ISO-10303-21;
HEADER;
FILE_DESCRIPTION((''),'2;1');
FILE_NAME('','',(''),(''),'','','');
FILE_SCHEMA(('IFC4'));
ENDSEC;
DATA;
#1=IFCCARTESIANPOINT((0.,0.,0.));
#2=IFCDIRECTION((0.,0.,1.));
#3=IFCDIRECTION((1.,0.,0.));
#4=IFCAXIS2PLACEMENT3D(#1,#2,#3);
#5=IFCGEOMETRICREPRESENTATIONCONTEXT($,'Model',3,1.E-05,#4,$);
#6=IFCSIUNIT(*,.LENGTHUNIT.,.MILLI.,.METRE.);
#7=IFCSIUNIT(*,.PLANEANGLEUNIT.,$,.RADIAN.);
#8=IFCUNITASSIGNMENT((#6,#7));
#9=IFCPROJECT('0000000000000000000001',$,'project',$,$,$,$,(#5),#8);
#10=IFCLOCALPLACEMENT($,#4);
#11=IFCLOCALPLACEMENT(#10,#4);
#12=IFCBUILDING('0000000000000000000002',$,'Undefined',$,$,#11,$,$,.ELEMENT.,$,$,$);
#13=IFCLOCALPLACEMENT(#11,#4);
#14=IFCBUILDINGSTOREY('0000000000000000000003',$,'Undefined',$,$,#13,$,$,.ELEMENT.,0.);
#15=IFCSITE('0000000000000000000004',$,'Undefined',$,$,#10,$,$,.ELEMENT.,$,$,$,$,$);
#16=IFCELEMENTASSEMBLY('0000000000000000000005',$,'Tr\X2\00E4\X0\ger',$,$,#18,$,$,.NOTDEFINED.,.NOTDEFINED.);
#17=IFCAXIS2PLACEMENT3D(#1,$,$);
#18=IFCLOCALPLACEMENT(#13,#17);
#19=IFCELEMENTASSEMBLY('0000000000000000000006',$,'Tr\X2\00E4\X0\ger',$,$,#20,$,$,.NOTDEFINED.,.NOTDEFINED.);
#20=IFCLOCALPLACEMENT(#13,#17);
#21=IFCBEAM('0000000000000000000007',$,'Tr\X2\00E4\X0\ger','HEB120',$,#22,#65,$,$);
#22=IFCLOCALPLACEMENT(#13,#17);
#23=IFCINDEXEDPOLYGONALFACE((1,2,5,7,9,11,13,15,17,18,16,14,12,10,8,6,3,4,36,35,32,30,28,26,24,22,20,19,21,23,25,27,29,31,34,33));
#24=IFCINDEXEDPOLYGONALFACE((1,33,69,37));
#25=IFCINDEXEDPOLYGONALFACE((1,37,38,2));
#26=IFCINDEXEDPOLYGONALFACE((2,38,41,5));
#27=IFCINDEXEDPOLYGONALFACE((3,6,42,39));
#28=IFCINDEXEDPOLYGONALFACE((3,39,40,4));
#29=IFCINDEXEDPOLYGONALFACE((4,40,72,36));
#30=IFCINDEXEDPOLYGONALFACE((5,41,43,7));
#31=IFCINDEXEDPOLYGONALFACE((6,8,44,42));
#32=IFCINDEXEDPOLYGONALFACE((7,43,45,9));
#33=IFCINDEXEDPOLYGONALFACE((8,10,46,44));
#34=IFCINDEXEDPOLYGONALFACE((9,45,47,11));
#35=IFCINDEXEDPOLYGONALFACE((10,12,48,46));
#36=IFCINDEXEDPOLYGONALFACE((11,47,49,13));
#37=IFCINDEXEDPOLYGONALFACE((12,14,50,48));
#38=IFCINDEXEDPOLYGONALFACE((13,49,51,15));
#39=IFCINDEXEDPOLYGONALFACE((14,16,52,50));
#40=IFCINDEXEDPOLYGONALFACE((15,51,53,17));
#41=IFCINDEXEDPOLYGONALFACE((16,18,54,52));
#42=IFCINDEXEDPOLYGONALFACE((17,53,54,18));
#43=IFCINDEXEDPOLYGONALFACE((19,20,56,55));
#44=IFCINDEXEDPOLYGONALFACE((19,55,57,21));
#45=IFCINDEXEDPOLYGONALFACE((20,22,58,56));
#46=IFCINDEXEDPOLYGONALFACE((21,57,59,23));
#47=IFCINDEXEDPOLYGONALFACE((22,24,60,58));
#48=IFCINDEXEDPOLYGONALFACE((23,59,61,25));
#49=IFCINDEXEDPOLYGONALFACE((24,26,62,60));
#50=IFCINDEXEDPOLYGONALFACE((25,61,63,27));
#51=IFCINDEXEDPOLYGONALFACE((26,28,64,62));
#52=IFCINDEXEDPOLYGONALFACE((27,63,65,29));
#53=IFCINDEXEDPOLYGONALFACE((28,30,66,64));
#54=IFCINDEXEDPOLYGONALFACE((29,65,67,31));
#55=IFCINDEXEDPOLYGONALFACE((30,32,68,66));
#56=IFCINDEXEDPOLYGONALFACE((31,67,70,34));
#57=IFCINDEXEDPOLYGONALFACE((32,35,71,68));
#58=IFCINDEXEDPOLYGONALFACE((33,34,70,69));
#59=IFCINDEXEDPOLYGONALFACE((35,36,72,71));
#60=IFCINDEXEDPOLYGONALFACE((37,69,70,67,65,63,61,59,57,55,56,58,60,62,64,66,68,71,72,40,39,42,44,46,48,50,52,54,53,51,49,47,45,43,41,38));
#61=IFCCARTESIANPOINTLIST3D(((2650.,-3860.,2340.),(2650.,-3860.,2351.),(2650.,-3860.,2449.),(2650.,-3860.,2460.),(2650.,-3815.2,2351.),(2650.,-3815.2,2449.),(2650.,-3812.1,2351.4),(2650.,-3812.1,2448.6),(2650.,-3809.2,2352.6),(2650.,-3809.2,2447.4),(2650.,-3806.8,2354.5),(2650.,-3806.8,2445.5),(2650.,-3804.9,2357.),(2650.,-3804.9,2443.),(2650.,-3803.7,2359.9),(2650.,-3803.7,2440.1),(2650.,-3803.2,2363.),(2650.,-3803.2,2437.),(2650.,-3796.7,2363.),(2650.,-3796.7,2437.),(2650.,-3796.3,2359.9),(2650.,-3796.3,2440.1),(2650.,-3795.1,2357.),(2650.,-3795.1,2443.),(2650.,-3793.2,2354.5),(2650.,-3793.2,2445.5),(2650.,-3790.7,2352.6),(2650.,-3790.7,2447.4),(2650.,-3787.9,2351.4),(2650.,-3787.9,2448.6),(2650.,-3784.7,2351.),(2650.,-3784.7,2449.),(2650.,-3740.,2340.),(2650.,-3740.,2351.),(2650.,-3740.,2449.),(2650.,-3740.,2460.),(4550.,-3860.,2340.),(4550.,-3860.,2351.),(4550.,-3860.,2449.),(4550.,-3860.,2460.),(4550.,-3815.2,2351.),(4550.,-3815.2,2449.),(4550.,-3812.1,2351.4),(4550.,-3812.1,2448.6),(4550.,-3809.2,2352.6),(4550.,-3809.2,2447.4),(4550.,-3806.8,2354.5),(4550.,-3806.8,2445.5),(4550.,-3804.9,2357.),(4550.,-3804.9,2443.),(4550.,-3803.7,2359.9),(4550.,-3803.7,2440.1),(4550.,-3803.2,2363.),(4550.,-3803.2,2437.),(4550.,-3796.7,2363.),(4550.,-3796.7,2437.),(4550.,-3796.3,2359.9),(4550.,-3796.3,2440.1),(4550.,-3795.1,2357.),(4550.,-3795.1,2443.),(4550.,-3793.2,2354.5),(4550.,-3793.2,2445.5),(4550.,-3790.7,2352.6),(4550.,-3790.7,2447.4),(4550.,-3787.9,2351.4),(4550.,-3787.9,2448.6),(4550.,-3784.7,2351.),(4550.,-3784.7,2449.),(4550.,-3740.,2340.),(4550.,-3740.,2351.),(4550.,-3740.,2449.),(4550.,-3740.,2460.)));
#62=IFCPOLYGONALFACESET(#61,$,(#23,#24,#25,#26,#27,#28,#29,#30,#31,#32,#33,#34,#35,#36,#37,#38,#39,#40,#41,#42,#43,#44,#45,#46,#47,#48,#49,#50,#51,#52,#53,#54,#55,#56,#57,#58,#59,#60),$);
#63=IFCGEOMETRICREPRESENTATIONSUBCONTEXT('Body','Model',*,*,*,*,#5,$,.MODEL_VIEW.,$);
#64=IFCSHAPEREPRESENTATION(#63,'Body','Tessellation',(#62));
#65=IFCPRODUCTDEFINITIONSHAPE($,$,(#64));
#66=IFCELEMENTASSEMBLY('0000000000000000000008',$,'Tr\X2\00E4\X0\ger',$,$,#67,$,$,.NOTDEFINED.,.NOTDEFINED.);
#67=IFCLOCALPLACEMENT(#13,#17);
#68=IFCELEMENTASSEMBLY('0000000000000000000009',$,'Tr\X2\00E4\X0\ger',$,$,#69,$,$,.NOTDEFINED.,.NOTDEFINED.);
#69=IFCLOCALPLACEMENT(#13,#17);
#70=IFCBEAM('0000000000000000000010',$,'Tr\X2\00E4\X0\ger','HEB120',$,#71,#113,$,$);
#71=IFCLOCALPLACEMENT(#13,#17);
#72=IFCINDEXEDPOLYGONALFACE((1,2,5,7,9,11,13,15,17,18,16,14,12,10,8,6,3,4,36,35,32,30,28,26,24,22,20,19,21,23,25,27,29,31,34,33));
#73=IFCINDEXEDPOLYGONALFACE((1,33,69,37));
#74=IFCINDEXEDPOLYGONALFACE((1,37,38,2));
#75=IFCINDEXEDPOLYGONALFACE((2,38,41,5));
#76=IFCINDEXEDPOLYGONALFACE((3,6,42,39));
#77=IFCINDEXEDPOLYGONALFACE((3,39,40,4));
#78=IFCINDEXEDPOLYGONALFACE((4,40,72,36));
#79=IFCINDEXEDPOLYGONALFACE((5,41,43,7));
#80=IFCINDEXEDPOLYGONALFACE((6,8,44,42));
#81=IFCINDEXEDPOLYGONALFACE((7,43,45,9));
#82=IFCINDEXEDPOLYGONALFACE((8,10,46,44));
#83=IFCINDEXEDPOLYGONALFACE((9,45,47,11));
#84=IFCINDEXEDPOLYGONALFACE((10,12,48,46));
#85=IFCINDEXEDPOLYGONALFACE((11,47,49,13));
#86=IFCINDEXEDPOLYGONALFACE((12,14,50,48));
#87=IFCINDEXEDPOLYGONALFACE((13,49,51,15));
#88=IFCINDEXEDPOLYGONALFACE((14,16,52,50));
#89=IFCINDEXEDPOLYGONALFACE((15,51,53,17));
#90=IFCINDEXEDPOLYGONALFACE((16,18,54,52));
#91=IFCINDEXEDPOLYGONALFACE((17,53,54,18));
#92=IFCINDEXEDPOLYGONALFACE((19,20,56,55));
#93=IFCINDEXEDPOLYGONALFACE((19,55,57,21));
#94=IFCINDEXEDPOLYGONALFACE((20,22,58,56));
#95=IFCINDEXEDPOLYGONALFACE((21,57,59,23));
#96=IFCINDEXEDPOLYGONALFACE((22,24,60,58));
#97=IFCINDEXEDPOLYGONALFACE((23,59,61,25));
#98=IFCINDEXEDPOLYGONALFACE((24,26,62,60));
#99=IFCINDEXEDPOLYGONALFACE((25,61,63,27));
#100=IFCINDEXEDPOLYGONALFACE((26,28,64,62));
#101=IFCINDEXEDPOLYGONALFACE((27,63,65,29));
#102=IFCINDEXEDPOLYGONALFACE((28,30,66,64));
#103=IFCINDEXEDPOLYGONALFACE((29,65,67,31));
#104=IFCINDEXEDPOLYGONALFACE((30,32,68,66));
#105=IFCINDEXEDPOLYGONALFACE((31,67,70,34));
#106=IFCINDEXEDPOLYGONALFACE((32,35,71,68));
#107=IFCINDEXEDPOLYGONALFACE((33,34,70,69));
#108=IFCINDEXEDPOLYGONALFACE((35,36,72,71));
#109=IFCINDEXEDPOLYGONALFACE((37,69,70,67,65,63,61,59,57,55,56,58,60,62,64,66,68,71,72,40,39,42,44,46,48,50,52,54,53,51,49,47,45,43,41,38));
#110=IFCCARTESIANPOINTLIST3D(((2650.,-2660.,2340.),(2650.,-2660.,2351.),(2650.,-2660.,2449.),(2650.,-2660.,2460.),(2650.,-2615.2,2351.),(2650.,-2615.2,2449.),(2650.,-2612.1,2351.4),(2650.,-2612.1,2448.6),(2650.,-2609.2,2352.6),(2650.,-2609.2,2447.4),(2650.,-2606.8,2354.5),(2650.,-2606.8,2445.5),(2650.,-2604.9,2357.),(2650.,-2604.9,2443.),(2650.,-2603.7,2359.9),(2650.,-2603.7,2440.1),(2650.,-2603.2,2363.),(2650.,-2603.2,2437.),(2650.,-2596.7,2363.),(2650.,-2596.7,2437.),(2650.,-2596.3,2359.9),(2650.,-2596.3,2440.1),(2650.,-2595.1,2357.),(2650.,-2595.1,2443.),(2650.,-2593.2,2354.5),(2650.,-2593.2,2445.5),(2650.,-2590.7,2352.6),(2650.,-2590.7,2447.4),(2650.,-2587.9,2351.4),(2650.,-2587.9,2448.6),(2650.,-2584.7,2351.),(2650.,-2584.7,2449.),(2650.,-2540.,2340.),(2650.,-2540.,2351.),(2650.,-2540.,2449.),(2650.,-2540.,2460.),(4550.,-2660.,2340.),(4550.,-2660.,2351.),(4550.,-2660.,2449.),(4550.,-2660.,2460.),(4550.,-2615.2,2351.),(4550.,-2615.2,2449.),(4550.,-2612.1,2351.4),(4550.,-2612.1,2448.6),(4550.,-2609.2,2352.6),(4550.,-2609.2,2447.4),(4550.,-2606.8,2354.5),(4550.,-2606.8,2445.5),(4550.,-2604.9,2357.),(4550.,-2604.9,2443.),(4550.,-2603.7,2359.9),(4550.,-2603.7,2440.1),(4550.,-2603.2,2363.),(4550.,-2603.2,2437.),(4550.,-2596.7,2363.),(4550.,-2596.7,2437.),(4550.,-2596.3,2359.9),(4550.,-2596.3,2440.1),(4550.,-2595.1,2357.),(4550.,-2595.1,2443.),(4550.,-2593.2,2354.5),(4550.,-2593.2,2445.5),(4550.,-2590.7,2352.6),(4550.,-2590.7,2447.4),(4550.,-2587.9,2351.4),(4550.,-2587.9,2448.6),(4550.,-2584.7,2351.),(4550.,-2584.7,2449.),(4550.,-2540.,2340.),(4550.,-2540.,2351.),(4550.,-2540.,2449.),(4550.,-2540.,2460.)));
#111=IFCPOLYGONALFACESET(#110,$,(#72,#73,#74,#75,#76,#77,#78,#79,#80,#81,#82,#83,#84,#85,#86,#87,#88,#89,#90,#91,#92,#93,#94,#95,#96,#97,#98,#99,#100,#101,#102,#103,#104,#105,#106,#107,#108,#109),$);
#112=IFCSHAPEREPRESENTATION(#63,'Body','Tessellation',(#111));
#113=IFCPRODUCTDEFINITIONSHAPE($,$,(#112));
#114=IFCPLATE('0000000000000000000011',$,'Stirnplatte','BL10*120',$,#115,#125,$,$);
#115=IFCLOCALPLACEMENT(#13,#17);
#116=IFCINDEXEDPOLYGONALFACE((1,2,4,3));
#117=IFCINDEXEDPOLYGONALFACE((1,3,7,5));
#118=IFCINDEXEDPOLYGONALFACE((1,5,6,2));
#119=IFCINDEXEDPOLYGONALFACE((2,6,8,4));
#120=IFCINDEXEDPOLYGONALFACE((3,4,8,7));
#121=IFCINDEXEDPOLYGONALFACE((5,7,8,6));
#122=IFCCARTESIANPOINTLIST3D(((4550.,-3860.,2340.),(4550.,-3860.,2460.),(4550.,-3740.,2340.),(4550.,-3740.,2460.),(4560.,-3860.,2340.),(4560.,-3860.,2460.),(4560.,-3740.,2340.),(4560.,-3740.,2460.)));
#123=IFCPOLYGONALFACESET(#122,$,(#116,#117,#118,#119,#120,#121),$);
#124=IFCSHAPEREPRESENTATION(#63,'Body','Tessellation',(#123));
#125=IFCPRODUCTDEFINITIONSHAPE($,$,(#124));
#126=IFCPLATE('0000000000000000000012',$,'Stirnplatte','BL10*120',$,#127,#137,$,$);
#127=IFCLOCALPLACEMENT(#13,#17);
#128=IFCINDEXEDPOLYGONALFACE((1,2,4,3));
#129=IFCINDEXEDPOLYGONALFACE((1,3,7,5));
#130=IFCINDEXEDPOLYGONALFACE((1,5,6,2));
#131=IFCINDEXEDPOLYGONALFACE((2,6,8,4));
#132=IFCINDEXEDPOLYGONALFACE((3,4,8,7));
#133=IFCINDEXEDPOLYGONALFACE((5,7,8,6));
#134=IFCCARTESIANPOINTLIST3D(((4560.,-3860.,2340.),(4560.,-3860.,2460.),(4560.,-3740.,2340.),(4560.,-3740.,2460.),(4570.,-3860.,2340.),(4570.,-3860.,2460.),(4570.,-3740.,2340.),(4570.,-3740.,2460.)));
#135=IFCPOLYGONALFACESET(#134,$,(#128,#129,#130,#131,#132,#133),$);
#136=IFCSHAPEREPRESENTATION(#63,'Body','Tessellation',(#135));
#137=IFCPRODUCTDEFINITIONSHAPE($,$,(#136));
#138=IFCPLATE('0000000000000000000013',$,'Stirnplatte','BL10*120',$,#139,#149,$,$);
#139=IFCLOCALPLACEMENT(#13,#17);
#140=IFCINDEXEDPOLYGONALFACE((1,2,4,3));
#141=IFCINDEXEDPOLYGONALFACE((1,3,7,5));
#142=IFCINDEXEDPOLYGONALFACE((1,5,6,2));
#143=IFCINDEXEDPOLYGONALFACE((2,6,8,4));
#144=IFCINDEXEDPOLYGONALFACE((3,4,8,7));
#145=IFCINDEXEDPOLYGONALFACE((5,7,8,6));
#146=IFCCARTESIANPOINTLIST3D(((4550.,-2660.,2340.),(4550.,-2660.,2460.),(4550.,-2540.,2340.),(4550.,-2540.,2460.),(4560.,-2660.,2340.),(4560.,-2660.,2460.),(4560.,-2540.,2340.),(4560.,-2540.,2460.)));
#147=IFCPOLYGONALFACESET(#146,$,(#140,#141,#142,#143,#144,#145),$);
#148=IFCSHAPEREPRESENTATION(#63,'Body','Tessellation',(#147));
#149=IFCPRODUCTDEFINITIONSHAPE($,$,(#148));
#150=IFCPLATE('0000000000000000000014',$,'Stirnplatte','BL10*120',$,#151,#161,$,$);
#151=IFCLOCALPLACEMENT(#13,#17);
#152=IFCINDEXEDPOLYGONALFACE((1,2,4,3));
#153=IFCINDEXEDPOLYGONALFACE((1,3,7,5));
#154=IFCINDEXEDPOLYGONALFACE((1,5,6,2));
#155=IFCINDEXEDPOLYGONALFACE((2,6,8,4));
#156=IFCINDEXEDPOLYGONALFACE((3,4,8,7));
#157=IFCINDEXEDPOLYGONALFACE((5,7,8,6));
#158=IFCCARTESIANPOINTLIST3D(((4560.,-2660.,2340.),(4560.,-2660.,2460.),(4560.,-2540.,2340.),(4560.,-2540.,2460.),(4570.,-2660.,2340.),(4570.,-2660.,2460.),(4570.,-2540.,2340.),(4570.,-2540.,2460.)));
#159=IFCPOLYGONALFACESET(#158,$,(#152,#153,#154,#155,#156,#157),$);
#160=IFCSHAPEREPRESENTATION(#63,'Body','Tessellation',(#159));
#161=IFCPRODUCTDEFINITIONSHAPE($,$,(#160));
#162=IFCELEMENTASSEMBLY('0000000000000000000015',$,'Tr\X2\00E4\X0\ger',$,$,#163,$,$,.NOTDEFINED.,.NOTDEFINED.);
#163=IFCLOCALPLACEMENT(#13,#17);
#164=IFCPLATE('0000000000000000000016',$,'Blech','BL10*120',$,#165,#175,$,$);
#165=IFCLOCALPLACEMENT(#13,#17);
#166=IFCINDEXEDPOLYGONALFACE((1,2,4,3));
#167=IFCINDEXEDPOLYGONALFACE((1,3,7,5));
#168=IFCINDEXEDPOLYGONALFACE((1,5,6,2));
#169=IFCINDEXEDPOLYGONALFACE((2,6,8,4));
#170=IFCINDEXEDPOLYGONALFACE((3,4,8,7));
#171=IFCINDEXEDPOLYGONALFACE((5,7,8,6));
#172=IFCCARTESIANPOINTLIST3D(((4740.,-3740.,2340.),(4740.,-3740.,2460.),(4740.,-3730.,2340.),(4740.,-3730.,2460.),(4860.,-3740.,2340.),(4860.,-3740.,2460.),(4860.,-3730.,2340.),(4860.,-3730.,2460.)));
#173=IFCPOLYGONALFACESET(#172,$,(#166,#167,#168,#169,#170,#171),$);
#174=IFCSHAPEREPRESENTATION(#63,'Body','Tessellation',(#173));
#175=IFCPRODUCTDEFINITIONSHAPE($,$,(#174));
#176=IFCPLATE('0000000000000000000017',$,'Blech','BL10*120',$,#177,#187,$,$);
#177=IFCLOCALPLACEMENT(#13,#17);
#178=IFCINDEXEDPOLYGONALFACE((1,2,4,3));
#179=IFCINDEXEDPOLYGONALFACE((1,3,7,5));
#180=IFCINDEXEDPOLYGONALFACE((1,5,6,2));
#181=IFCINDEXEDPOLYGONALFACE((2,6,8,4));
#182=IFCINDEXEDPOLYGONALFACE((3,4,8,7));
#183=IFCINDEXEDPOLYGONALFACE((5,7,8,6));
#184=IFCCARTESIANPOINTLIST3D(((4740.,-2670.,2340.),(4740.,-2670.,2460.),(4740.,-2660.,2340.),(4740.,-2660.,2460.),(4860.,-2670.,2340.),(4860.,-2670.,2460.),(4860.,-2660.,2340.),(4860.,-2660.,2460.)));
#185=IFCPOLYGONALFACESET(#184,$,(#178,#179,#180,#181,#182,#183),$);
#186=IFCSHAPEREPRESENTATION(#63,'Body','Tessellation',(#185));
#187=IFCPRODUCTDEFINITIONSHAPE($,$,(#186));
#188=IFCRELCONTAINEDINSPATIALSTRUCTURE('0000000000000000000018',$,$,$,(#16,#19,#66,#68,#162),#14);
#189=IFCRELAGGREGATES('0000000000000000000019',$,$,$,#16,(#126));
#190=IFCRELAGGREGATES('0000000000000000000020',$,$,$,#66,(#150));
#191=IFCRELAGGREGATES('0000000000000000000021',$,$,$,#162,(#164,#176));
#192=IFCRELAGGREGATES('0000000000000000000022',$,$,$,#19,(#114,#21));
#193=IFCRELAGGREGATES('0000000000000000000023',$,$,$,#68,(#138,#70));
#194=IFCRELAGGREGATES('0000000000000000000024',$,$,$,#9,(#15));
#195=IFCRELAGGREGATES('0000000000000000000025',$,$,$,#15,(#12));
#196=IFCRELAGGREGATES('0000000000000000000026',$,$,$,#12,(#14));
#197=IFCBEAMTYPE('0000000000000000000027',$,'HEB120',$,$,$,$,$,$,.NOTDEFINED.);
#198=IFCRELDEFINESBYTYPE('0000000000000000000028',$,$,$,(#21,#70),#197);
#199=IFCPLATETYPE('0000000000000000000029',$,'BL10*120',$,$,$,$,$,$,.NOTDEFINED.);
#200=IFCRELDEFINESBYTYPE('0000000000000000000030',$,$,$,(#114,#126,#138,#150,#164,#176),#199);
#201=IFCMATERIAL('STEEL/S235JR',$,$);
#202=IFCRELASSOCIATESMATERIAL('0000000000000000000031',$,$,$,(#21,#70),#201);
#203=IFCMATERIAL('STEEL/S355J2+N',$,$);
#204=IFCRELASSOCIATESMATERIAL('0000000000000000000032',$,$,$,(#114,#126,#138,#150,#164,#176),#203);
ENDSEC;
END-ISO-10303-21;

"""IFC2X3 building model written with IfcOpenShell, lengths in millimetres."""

from ifc_helpers import new_model, si_unit, frame, origin_with_axes, origin_2d_with_axis, place, context, subcontext, project, spatial, polyline, i_section, outline, extrude, clip, halfspace, material, type_object, element, aggregate, save


model = new_model("IFC2X3")

# Units and contexts
model_context = context("Model", 3, precision=1e-05, world=origin_with_axes())
body_context = subcontext(model_context, "Body", "Model", "MODEL_VIEW")
ifc_project = project(units=[si_unit("LENGTHUNIT", "METRE", prefix="MILLI"), si_unit("PLANEANGLEUNIT", "RADIAN")], contexts=[model_context])

# Site, building, storey
site_placement = place(None, origin_with_axes())
site = spatial("IfcSite", under=ifc_project, at=site_placement, Name="Undefined", CompositionType="ELEMENT")
building_placement = place(site_placement, origin_with_axes())
building = spatial("IfcBuilding", under=site, at=building_placement, Name="Undefined", CompositionType="ELEMENT")
storey_placement = place(building_placement, origin_with_axes())
storey = spatial("IfcBuildingStorey", under=building, at=storey_placement, Name="Undefined", CompositionType="ELEMENT", Elevation=0.0)

# Element assemblies, beams
assembly_1_placement = place(storey_placement, origin_with_axes())
assembly_1 = element("IfcElementAssembly", 1, at=assembly_1_placement, inside=storey, Name="Träger", AssemblyPlace="NOTDEFINED", PredefinedType="NOTDEFINED")
ifc_material_1 = material(Name="STEEL/S235JR")
beam_type = type_object("IfcBeamType", Name="HEB120", PredefinedType="NOTDEFINED")
assembly_2_placement = place(storey_placement, origin_with_axes())
assembly_2 = element("IfcElementAssembly", 2, at=assembly_2_placement, inside=storey, Name="Träger", AssemblyPlace="NOTDEFINED", PredefinedType="NOTDEFINED")
beam_1_placement = place(assembly_2_placement, frame((4550.0, -3800.0, 2400.0), z_axis=(0.0, 0.0, 1.0), x_axis=(-1.0, 0.0, 0.0)))
beam_1 = element("IfcBeam", 3, at=beam_1_placement, type_object=beam_type, material=ifc_material_1, Name="Träger", Description="HEB120", context=body_context, shape_type="Clipping", body=[
    clip(clip(extrude(i_section(OverallWidth=120.0, OverallDepth=120.0, WebThickness=6.5, FlangeThickness=11.0, FilletRadius=12.0, at=origin_2d_with_axis()), frame((1910.0, 0.0, 0.0), z_axis=(-1.0, 0.0, 0.0), x_axis=(0.0, -1.0, 0.0)), (0.0, 0.0, 1.0), 1910.0), halfspace(frame((1900.0, 0.0, -60.0), z_axis=(-1.0, 0.0, 0.0), x_axis=(0.0, 1.0, 0.0)), True)), halfspace(frame((0.0, 0.0, -60.0), z_axis=(1.0, 0.0, 0.0), x_axis=(0.0, -1.0, 0.0)), True)),
])
assembly_3_placement = place(storey_placement, origin_with_axes())
assembly_3 = element("IfcElementAssembly", 4, at=assembly_3_placement, inside=storey, Name="Träger", AssemblyPlace="NOTDEFINED", PredefinedType="NOTDEFINED")
assembly_4_placement = place(storey_placement, origin_with_axes())
assembly_4 = element("IfcElementAssembly", 5, at=assembly_4_placement, inside=storey, Name="Träger", AssemblyPlace="NOTDEFINED", PredefinedType="NOTDEFINED")
beam_2_placement = place(assembly_4_placement, frame((4550.0, -2600.0, 2400.0), z_axis=(0.0, 0.0, 1.0), x_axis=(-1.0, 0.0, 0.0)))
beam_2 = element("IfcBeam", 6, at=beam_2_placement, type_object=beam_type, material=ifc_material_1, Name="Träger", Description="HEB120", context=body_context, shape_type="Clipping", body=[
    clip(clip(extrude(i_section(OverallWidth=120.0, OverallDepth=120.0, WebThickness=6.5, FlangeThickness=11.0, FilletRadius=12.0, at=origin_2d_with_axis()), frame((1910.0, 0.0, 0.0), z_axis=(-1.0, 0.0, 0.0), x_axis=(0.0, -1.0, 0.0)), (0.0, 0.0, 1.0), 1910.0), halfspace(frame((1900.0, 0.0, -60.0), z_axis=(-1.0, 0.0, 0.0), x_axis=(0.0, 1.0, 0.0)), True)), halfspace(frame((0.0, 0.0, -60.0), z_axis=(1.0, 0.0, 0.0), x_axis=(0.0, -1.0, 0.0)), True)),
])

# Plates
ifc_material_2 = material(Name="STEEL/S355J2+N")
plate_type = type_object("IfcPlateType", Name="BL10*120", PredefinedType="NOTDEFINED")
plate_1_placement = place(assembly_2_placement, frame((4555.0, -3800.0, 2340.0), z_axis=(-1.0, 0.0, 0.0), x_axis=(0.0, 0.0, 1.0)))
plate_1 = element("IfcPlate", 7, at=plate_1_placement, type_object=plate_type, material=ifc_material_2, Name="Stirnplatte", Description="BL10*120", context=body_context, shape_type="SweptSolid", body=[
    extrude(outline(polyline([(0.0, -60.0), (0.0, 60.0), (120.0, 60.0), (120.0, -60.0), (0.0, -60.0)])), frame((0.0, 0.0, -5.0), z_axis=(0.0, 0.0, 1.0), x_axis=(1.0, 0.0, 0.0)), (0.0, 0.0, 1.0), 10.0),
])
plate_2_placement = place(assembly_1_placement, frame((4565.0, -3800.0, 2340.0), z_axis=(-1.0, 0.0, 0.0), x_axis=(0.0, 0.0, 1.0)))
plate_2 = element("IfcPlate", 8, at=plate_2_placement, type_object=plate_type, material=ifc_material_2, Name="Stirnplatte", Description="BL10*120", context=body_context, shape_type="SweptSolid", body=[
    extrude(outline(polyline([(0.0, -60.0), (0.0, 60.0), (120.0, 60.0), (120.0, -60.0), (0.0, -60.0)])), frame((0.0, 0.0, -5.0), z_axis=(0.0, 0.0, 1.0), x_axis=(1.0, 0.0, 0.0)), (0.0, 0.0, 1.0), 10.0),
])
aggregate(assembly_1, [plate_2])
plate_3_placement = place(assembly_4_placement, frame((4555.0, -2600.0, 2340.0), z_axis=(-1.0, 0.0, 0.0), x_axis=(0.0, 0.0, 1.0)))
plate_3 = element("IfcPlate", 9, at=plate_3_placement, type_object=plate_type, material=ifc_material_2, Name="Stirnplatte", Description="BL10*120", context=body_context, shape_type="SweptSolid", body=[
    extrude(outline(polyline([(0.0, -60.0), (0.0, 60.0), (120.0, 60.0), (120.0, -60.0), (0.0, -60.0)])), frame((0.0, 0.0, -5.0), z_axis=(0.0, 0.0, 1.0), x_axis=(1.0, 0.0, 0.0)), (0.0, 0.0, 1.0), 10.0),
])
plate_4_placement = place(assembly_3_placement, frame((4565.0, -2600.0, 2340.0), z_axis=(-1.0, 0.0, 0.0), x_axis=(0.0, 0.0, 1.0)))
plate_4 = element("IfcPlate", 10, at=plate_4_placement, type_object=plate_type, material=ifc_material_2, Name="Stirnplatte", Description="BL10*120", context=body_context, shape_type="SweptSolid", body=[
    extrude(outline(polyline([(0.0, -60.0), (0.0, 60.0), (120.0, 60.0), (120.0, -60.0), (0.0, -60.0)])), frame((0.0, 0.0, -5.0), z_axis=(0.0, 0.0, 1.0), x_axis=(1.0, 0.0, 0.0)), (0.0, 0.0, 1.0), 10.0),
])
aggregate(assembly_3, [plate_4])

# Element assembly, plates
assembly_5_placement = place(storey_placement, origin_with_axes())
assembly_5 = element("IfcElementAssembly", 11, at=assembly_5_placement, inside=storey, Name="Träger", AssemblyPlace="NOTDEFINED", PredefinedType="NOTDEFINED")
plate_5_placement = place(assembly_5_placement, frame((4800.0, -3735.0, 2340.0), z_axis=(0.0, 1.0, 0.0), x_axis=(0.0, 0.0, 1.0)))
plate_5 = element("IfcPlate", 12, at=plate_5_placement, type_object=plate_type, material=ifc_material_2, Name="Blech", Description="BL10*120", context=body_context, shape_type="SweptSolid", body=[
    extrude(outline(polyline([(0.0, -60.0), (0.0, 60.0), (120.0, 60.0), (120.0, -60.0), (0.0, -60.0)])), frame((0.0, 0.0, -5.0), z_axis=(0.0, 0.0, 1.0), x_axis=(1.0, 0.0, 0.0)), (0.0, 0.0, 1.0), 10.0),
])
plate_6_placement = place(assembly_5_placement, frame((4800.0, -2665.0, 2340.0), z_axis=(0.0, -1.0, 0.0), x_axis=(0.0, 0.0, 1.0)))
plate_6 = element("IfcPlate", 13, at=plate_6_placement, type_object=plate_type, material=ifc_material_2, Name="Blech", Description="BL10*120", context=body_context, shape_type="SweptSolid", body=[
    extrude(outline(polyline([(0.0, -60.0), (0.0, 60.0), (120.0, 60.0), (120.0, -60.0), (0.0, -60.0)])), frame((0.0, 0.0, -5.0), z_axis=(0.0, 0.0, 1.0), x_axis=(1.0, 0.0, 0.0)), (0.0, 0.0, 1.0), 10.0),
])
aggregate(assembly_5, [plate_5, plate_6])

aggregate(assembly_2, [plate_1, beam_1])
aggregate(assembly_4, [plate_3, beam_2])

save(model, "model.ifc")
